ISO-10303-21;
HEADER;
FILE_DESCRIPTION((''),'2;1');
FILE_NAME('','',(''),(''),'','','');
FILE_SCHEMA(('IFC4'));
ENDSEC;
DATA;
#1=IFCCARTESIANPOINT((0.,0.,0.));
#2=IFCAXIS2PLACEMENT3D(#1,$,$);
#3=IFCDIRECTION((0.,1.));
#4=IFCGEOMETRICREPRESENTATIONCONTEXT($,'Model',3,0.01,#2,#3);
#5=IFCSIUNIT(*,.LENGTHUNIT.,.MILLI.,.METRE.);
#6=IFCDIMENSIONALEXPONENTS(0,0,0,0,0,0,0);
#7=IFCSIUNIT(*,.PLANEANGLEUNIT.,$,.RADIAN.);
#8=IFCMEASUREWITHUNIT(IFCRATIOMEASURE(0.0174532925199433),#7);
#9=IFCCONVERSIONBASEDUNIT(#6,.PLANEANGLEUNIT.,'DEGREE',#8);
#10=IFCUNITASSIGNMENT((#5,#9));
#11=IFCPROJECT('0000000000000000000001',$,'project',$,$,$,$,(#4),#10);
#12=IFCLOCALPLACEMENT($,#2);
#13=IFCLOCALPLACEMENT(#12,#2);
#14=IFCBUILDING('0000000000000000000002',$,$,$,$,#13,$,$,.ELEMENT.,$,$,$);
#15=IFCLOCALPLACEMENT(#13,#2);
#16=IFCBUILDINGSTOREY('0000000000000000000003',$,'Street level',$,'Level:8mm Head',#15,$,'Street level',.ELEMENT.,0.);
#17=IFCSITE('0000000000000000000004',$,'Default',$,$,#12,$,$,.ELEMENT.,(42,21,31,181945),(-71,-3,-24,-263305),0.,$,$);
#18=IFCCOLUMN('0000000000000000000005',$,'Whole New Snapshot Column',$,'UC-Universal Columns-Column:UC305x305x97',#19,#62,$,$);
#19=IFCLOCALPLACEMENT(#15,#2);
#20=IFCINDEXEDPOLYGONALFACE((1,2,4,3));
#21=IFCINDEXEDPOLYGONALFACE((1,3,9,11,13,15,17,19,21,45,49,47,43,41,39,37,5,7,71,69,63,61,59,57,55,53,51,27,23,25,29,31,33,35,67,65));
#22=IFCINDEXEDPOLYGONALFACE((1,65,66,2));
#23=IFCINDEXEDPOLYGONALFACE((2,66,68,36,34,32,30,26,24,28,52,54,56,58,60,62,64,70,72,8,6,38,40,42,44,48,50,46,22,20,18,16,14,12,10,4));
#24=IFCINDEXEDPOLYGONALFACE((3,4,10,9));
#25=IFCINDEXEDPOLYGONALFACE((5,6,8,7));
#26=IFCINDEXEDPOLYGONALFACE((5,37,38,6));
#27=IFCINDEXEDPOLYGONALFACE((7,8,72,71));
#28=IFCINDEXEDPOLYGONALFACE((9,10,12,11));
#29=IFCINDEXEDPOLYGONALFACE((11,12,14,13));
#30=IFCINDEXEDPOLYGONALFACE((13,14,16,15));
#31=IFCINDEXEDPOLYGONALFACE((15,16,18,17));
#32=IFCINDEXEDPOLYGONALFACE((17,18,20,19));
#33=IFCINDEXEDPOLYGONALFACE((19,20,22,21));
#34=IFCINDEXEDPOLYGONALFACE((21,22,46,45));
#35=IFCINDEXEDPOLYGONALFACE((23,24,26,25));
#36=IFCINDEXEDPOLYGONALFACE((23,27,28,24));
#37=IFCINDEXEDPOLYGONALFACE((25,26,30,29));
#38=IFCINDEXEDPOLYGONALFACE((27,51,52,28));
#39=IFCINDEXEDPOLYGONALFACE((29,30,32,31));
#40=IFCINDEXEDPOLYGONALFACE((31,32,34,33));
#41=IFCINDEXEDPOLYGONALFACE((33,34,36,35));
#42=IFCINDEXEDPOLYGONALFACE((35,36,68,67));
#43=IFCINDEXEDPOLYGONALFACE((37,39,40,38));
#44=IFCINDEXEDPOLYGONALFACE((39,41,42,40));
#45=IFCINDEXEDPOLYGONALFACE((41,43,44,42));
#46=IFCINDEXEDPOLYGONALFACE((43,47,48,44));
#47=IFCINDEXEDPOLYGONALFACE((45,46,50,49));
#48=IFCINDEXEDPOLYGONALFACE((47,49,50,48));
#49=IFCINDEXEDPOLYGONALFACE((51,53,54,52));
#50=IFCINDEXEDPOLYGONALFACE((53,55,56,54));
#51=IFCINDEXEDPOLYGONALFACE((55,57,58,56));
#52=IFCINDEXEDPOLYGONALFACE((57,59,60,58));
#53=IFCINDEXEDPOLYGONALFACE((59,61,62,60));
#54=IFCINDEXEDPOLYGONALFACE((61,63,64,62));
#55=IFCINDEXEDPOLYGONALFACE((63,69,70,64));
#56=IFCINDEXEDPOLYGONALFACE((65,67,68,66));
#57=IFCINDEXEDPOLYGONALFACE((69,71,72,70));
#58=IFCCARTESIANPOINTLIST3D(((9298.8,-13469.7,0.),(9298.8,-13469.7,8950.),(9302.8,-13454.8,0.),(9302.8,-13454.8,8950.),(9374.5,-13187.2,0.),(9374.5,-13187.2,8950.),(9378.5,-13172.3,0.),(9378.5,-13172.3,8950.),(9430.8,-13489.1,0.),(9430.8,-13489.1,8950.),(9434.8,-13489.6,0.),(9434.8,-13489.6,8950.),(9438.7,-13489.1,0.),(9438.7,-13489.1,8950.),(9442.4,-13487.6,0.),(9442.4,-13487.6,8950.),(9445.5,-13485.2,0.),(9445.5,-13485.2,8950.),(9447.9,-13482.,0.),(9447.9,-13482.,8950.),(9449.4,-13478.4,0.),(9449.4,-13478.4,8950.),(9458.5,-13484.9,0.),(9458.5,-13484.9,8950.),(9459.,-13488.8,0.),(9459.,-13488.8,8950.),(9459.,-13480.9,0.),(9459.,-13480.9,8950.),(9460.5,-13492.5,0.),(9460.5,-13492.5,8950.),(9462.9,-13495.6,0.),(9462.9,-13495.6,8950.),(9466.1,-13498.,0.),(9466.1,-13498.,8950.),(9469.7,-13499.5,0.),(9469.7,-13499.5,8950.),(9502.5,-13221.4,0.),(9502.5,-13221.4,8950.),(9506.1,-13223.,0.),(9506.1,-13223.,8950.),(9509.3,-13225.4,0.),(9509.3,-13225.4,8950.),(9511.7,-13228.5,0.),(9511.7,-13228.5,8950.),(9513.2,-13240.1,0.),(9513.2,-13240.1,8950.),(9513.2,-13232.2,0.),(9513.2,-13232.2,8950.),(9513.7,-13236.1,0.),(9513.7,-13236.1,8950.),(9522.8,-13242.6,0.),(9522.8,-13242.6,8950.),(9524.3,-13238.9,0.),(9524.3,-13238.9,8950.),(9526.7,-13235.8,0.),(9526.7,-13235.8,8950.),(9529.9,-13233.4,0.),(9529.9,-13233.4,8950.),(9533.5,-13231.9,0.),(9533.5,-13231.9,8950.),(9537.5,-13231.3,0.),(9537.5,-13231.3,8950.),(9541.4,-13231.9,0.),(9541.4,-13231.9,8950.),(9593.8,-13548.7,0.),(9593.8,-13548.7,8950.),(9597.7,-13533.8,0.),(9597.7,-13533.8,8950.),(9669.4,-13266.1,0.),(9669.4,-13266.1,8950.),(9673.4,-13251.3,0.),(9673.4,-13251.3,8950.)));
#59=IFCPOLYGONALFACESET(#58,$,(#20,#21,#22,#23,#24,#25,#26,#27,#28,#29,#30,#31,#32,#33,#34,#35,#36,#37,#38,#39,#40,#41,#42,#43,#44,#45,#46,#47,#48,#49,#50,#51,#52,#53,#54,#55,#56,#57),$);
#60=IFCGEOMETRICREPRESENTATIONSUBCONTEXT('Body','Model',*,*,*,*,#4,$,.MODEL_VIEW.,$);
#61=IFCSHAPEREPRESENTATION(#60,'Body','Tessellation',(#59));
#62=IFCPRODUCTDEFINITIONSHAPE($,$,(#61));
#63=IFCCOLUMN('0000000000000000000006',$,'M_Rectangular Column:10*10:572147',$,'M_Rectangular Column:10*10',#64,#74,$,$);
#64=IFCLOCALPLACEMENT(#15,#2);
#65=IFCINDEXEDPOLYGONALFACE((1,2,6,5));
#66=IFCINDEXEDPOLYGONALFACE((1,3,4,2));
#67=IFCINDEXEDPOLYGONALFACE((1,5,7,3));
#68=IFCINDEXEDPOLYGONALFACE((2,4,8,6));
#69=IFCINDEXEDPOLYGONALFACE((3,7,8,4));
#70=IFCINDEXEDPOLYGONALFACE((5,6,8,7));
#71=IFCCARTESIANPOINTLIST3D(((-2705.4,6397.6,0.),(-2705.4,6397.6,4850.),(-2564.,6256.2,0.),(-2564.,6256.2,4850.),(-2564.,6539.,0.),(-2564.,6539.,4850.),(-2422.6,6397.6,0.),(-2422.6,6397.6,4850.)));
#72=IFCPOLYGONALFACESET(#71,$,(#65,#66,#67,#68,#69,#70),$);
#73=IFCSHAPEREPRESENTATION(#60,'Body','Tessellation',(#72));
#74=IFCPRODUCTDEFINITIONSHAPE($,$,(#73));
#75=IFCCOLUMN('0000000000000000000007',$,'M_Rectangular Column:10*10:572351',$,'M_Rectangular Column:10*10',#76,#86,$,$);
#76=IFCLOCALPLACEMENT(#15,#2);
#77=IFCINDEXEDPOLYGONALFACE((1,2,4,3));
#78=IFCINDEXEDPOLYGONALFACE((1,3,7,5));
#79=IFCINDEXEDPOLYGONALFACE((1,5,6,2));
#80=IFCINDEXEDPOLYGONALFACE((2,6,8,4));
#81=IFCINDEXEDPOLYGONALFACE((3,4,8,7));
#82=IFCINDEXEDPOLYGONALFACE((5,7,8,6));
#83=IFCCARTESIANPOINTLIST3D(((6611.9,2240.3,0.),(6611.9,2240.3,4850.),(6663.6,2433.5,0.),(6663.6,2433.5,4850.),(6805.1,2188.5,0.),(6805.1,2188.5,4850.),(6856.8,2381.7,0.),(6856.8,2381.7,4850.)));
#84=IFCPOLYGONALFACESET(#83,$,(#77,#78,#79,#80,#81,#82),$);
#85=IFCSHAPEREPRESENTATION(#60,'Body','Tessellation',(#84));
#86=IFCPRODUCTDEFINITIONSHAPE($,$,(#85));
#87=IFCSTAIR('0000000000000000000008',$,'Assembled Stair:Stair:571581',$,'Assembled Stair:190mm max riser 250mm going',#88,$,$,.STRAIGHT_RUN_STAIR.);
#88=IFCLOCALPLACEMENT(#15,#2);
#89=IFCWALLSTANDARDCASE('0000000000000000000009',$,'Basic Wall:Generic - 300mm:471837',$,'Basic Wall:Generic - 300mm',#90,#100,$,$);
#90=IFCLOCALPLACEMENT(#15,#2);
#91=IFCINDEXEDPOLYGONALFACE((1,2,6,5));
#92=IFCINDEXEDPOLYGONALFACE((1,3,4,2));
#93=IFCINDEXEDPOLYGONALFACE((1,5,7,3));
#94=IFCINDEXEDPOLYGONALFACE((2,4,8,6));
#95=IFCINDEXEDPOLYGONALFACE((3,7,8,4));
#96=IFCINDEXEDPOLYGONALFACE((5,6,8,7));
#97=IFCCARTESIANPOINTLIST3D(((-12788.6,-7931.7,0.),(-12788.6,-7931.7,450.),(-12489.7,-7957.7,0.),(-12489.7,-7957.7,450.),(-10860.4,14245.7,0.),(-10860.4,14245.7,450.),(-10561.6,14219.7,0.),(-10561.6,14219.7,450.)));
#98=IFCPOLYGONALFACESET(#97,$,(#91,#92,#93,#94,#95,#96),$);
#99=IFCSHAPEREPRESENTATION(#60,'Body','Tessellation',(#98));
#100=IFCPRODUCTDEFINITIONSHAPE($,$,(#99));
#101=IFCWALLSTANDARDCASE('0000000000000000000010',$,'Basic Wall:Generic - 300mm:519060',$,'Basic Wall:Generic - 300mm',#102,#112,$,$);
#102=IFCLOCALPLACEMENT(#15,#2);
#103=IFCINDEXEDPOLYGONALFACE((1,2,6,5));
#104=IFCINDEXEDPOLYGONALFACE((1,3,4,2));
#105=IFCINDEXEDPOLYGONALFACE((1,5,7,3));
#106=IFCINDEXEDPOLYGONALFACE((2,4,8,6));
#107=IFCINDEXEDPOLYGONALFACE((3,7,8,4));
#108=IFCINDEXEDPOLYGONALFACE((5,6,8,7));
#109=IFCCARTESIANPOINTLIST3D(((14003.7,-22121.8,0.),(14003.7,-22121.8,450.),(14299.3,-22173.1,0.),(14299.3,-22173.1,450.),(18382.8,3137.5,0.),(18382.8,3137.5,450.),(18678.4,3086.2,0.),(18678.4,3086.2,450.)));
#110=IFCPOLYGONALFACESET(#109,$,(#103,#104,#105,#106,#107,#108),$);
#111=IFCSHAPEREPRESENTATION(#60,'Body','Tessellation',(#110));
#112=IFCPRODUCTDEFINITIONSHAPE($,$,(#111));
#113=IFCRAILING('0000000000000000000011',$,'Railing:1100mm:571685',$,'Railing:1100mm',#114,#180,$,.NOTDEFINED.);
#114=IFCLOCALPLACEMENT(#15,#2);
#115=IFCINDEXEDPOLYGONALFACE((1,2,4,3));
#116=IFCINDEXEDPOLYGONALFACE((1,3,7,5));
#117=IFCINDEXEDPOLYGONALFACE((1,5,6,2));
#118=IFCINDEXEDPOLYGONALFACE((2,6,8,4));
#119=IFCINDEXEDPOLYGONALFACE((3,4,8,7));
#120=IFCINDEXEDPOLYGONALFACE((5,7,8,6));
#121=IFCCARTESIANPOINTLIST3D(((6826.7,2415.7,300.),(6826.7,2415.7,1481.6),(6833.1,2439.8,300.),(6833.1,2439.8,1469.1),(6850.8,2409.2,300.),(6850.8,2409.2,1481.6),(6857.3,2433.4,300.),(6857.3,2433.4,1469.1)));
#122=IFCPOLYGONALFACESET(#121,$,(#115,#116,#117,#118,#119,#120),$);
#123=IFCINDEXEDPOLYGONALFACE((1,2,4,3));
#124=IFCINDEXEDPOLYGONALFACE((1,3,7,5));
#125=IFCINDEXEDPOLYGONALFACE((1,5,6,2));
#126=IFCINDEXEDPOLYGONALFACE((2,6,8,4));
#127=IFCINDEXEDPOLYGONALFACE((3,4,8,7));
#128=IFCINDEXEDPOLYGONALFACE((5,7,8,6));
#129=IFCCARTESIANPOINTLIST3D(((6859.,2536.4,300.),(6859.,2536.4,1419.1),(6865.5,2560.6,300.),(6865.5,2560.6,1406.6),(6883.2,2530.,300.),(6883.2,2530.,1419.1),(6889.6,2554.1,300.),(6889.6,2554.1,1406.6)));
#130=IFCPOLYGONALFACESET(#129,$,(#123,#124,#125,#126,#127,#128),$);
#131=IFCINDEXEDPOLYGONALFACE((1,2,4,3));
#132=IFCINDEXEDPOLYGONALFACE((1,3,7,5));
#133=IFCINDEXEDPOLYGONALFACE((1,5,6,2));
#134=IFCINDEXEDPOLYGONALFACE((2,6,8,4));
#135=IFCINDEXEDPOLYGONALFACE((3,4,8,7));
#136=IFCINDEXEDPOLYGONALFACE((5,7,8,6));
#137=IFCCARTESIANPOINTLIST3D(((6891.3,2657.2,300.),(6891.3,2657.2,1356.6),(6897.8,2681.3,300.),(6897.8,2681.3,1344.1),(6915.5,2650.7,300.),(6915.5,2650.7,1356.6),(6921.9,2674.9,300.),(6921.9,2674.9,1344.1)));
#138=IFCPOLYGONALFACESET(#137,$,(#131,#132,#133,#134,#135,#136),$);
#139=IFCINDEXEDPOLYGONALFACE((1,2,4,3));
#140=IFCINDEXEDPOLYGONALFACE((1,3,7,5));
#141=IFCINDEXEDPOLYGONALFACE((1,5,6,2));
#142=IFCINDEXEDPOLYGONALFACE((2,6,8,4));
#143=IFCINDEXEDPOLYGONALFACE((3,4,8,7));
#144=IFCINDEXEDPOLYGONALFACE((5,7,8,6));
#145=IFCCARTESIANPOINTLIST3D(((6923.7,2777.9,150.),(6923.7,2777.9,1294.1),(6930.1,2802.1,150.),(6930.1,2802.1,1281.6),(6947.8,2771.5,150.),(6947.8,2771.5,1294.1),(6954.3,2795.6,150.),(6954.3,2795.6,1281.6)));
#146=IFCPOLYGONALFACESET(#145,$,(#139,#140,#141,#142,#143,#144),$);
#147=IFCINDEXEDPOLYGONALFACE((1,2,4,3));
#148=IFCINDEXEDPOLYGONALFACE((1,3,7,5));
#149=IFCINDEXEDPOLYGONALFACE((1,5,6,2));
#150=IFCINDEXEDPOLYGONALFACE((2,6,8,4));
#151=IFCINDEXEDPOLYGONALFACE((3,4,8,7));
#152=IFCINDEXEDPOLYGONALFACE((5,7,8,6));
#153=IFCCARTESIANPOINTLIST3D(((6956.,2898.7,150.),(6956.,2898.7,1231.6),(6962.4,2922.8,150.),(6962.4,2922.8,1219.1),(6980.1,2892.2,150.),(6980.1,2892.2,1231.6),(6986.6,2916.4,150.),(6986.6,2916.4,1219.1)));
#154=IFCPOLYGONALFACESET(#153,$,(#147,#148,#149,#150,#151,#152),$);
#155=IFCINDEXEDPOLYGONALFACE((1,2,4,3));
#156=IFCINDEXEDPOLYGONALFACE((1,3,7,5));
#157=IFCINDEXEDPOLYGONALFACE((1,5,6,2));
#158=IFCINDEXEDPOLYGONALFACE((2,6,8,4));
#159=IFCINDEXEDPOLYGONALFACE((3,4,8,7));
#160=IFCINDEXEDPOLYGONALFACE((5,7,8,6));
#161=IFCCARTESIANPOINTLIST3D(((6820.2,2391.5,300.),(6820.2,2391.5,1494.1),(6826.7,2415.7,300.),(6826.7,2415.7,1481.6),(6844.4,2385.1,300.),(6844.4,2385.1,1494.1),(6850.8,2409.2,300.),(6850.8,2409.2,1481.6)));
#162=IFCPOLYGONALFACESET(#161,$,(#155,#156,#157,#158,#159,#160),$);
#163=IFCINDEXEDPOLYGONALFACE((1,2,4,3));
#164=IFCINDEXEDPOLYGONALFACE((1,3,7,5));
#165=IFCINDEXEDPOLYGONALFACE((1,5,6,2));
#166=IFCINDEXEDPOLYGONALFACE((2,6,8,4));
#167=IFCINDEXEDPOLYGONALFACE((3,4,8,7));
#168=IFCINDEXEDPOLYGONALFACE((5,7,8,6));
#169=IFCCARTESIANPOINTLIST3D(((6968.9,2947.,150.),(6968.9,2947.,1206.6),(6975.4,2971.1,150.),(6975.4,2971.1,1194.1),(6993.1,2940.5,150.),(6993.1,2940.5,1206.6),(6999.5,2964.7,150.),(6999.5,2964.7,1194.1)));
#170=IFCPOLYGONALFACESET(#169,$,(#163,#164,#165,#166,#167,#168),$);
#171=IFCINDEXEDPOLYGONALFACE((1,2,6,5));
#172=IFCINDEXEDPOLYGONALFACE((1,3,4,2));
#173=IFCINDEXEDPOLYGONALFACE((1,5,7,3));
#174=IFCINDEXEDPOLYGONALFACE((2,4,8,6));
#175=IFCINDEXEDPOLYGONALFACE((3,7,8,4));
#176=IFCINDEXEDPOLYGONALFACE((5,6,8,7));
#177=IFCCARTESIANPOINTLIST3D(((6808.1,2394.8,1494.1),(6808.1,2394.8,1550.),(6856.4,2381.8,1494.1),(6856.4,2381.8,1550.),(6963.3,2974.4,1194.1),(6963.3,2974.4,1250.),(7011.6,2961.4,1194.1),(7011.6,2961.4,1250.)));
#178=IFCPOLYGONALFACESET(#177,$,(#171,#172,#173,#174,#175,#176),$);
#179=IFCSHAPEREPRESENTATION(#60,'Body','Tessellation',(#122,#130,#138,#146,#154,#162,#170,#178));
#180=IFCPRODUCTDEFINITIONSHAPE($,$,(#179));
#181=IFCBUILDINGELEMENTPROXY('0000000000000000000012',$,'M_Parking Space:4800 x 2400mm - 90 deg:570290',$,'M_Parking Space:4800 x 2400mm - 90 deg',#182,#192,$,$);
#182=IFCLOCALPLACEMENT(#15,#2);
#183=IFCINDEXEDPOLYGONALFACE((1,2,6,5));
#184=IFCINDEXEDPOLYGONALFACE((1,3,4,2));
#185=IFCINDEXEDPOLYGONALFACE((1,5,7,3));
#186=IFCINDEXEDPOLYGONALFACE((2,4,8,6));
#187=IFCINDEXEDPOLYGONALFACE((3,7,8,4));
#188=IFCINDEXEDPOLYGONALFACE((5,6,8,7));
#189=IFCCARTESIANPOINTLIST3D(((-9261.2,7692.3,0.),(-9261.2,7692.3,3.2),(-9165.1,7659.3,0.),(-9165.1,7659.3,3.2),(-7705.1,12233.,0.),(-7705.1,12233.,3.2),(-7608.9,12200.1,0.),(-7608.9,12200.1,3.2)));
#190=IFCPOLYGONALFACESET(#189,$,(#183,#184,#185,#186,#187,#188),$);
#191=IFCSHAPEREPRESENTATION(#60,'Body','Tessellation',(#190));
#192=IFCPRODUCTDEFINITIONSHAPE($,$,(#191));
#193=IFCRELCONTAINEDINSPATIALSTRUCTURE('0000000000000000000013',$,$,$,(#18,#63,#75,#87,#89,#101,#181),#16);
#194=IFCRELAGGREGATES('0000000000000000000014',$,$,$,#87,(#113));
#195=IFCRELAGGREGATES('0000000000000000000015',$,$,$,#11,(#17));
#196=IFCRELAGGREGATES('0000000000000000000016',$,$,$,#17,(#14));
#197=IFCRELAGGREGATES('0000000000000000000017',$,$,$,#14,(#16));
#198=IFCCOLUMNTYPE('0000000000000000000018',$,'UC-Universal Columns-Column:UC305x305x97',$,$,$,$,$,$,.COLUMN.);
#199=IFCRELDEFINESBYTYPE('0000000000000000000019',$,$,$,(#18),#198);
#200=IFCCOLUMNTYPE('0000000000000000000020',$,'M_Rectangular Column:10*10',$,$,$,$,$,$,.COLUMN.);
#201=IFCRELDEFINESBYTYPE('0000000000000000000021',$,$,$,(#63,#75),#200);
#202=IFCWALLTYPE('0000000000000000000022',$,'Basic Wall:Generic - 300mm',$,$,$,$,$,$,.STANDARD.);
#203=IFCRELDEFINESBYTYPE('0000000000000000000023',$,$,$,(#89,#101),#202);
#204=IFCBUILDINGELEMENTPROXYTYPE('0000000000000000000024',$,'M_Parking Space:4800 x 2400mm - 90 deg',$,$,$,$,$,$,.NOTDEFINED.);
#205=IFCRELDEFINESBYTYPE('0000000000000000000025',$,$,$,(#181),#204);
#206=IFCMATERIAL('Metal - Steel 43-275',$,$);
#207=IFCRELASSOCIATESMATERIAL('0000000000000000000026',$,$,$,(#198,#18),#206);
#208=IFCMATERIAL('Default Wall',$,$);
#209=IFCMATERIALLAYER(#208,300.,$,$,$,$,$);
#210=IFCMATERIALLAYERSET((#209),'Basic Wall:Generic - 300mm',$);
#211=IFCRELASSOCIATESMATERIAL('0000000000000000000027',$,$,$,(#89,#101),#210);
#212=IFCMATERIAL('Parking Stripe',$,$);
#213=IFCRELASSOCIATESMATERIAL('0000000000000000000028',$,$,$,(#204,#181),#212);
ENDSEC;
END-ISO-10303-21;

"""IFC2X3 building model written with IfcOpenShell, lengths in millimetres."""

from ifc_helpers import new_model, entity, si_unit, converted_unit, direction, frame, frame_2d, origin, origin_2d_with_axis, place, context, subcontext, project, spatial, polyline, rectangle, i_section, outline, extrude, source, transform, mapped, material, layer, layer_set, layer_usage, type_object, type_shapes, element, aggregate, save


model = new_model("IFC2X3")

# Units and contexts
model_context = context("Model", 3, precision=0.01, world=origin(), true_north=direction((0.0, 1.0)))
body_context = subcontext(model_context, "Body", "Model", "MODEL_VIEW")
ifc_project = project(units=[si_unit("LENGTHUNIT", "METRE", prefix="MILLI"), converted_unit("PLANEANGLEUNIT", "DEGREE", entity("IfcRatioMeasure", 0.0174532925199433), si_unit("PLANEANGLEUNIT", "RADIAN"), dimensions=[0, 0, 0, 0, 0, 0, 0])], contexts=[model_context])

# Site, building, storey
site_placement = place(None, origin())
site = spatial("IfcSite", under=ifc_project, at=site_placement, Name="Default", CompositionType="ELEMENT", RefLatitude=(42, 21, 31, 181945), RefLongitude=(-71, -3, -24, -263305), RefElevation=0.0)
building_placement = place(site_placement, origin())
building = spatial("IfcBuilding", under=site, at=building_placement, CompositionType="ELEMENT")
storey_placement = place(building_placement, origin())
storey = spatial("IfcBuildingStorey", under=building, at=storey_placement, Name="Street level", ObjectType="Level:8mm Head", LongName="Street level", CompositionType="ELEMENT", Elevation=0.0)

# Columns
ifc_material_1 = material(Name="Metal - Steel 43-275")
column_type_1 = type_object("IfcColumnType", Name="UC-Universal Columns-Column:UC305x305x97", PredefinedType="COLUMN", material=ifc_material_1)
shared_shape_1 = source(origin(), body_context, "Body", "SweptSolid", [
    extrude(i_section(OverallWidth=305.3, OverallDepth=307.9, WebThickness=9.9, FlangeThickness=15.4, FilletRadius=15.2, at=frame_2d((0.0, 0.0), x_axis=(0.0, 1.0))), frame((0.0, 0.0, 0.0), z_axis=(0.0, 0.0, 1.0), x_axis=(0.0, -1.0, 0.0)), (0.0, 0.0, 1.0), 8950.0),
])
type_shapes(column_type_1, [shared_shape_1])
column_placement = place(storey_placement, frame((9486.1, -13360.5, 0.0), z_axis=(0.0, 0.0, 1.0), x_axis=(0.965983, -0.258607, 0.0)))
element("IfcColumn", 1, at=column_placement, inside=storey, type_object=column_type_1, material=ifc_material_1, Name="Whole New Snapshot Column", ObjectType="UC-Universal Columns-Column:UC305x305x97", context=body_context, shape_type="MappedRepresentation", body=[
    mapped(shared_shape_1, transform((0.0, 0.0, 0.0), scale=1.0)),
])
column_type_2 = type_object("IfcColumnType", Name="M_Rectangular Column:10*10", PredefinedType="COLUMN")
shared_shape_2 = source(origin(), body_context, "Body", "SweptSolid", [
    extrude(rectangle(XDim=200.0, YDim=200.0, at=origin_2d_with_axis()), frame((0.0, 0.0, 0.0), z_axis=(0.0, 0.0, 1.0), x_axis=(0.0, -1.0, 0.0)), (0.0, 0.0, 1.0), 4850.0),
])
type_shapes(column_type_2, [shared_shape_2])
for number, where, z_axis, x_axis, name in (
    (2, (-2564.0, 6397.6, 0.0), (0.0, 0.0, 1.0), (0.707107, 0.707107, 0.0), "M_Rectangular Column:10*10:572147"),
    (3, (6734.4, 2311.0, 0.0), (0.0, 0.0, 1.0), (0.258607, 0.965983, 0.0), "M_Rectangular Column:10*10:572351"),
):
    element("IfcColumn", number, at=place(storey_placement, frame(where, z_axis=z_axis, x_axis=x_axis)), inside=storey, type_object=column_type_2, Name=name, ObjectType="M_Rectangular Column:10*10", context=body_context, shape_type="MappedRepresentation", body=[
        mapped(shared_shape_2, transform((0.0, 0.0, 0.0), scale=1.0)),
    ])

# Stair
stair_placement = place(storey_placement, origin())
stair = element("IfcStair", 4, at=stair_placement, inside=storey, Name="Assembled Stair:Stair:571581", ObjectType="Assembled Stair:190mm max riser 250mm going", ShapeType="STRAIGHT_RUN_STAIR")

# Walls
ifc_material_2 = material(Name="Default Wall")
ifc_layer_1 = layer(ifc_material_2, 300.0)
ifc_layer_set_1 = layer_set([ifc_layer_1], Name="Basic Wall:Generic - 300mm")
ifc_layer_usage_1 = layer_usage(ifc_layer_set_1, "AXIS2", "NEGATIVE", 150.0)
wall_type = type_object("IfcWallType", Name="Basic Wall:Generic - 300mm", PredefinedType="STANDARD")
wall_1_placement = place(storey_placement, frame((-10711.0, 14232.7, 0.0), z_axis=(0.0, 0.0, 1.0), x_axis=(-0.086615, -0.996242, 0.0)))
element("IfcWallStandardCase", 5, at=wall_1_placement, inside=storey, type_object=wall_type, material=ifc_layer_usage_1, Name="Basic Wall:Generic - 300mm:471837", ObjectType="Basic Wall:Generic - 300mm", context=body_context, shape_type="SweptSolid", body=[
    extrude(rectangle(XDim=22261.1, YDim=300.0, at=frame_2d((11130.5, 0.0), x_axis=(-1.0, 0.0))), origin(), (0.0, 0.0, 1.0), 450.0),
])
ifc_layer_usage_2 = layer_usage(ifc_layer_set_1, "AXIS2", "NEGATIVE", 150.0)
wall_2_placement = place(storey_placement, frame((14151.5, -22147.4, 0.0), z_axis=(0.0, 0.0, 1.0), x_axis=(0.17082, 0.985302, 0.0)))
element("IfcWallStandardCase", 6, at=wall_2_placement, inside=storey, type_object=wall_type, material=ifc_layer_usage_2, Name="Basic Wall:Generic - 300mm:519060", ObjectType="Basic Wall:Generic - 300mm", context=body_context, shape_type="SweptSolid", body=[
    extrude(rectangle(XDim=25636.1, YDim=300.0, at=frame_2d((12818.0, 0.0), x_axis=(-1.0, 0.0))), origin(), (0.0, 0.0, 1.0), 450.0),
])

# Railing
railing_placement = place(stair_placement, origin())
railing = element("IfcRailing", 7, at=railing_placement, Name="Railing:1100mm:571685", ObjectType="Railing:1100mm", PredefinedType="NOTDEFINED", context=body_context, shape_type="SweptSolid", body=[
    extrude(outline(polyline([(-587.7, -12.5), (581.4, -12.5), (593.9, 12.5), (-587.7, 12.5), (-587.7, -12.5)])), frame((6829.9, 2427.8, 887.7), z_axis=(0.965983, -0.258606, 0.0), x_axis=(0.0, 0.0, 1.0)), (0.0, 0.0, 1.0), 25.0),
    extrude(outline(polyline([(-556.4, -12.5), (550.2, -12.5), (562.7, 12.5), (-556.4, 12.5), (-556.4, -12.5)])), frame((6862.2, 2548.5, 856.4), z_axis=(0.965983, -0.258606, 0.0), x_axis=(0.0, 0.0, 1.0)), (0.0, 0.0, 1.0), 25.0),
    extrude(outline(polyline([(-525.2, -12.5), (518.9, -12.5), (531.4, 12.5), (-525.2, 12.5), (-525.2, -12.5)])), frame((6894.6, 2669.3, 825.2), z_axis=(0.965983, -0.258606, 0.0), x_axis=(0.0, 0.0, 1.0)), (0.0, 0.0, 1.0), 25.0),
    extrude(outline(polyline([(-568.9, -12.5), (562.7, -12.5), (575.2, 12.5), (-568.9, 12.5), (-568.9, -12.5)])), frame((6926.9, 2790.0, 718.9), z_axis=(0.965983, -0.258606, 0.0), x_axis=(0.0, 0.0, 1.0)), (0.0, 0.0, 1.0), 25.0),
    extrude(outline(polyline([(-537.7, -12.5), (531.4, -12.5), (543.9, 12.5), (-537.7, 12.5), (-537.7, -12.5)])), frame((6959.2, 2910.8, 687.7), z_axis=(0.965983, -0.258606, 0.0), x_axis=(0.0, 0.0, 1.0)), (0.0, 0.0, 1.0), 25.0),
    extrude(outline(polyline([(-593.9, -12.5), (587.7, -12.5), (600.2, 12.5), (-593.9, 12.5), (-593.9, -12.5)])), frame((6823.4, 2403.6, 893.9), z_axis=(0.965983, -0.258606, 0.0), x_axis=(0.0, 0.0, 1.0)), (0.0, 0.0, 1.0), 25.0),
    extrude(outline(polyline([(-525.2, -12.5), (518.9, -12.5), (531.4, 12.5), (-525.2, 12.5), (-525.2, -12.5)])), frame((6972.1, 2959.1, 675.2), z_axis=(0.965983, -0.258606, 0.0), x_axis=(0.0, 0.0, 1.0)), (0.0, 0.0, 1.0), 25.0),
    extrude(outline(polyline([(-322.9, -25.0), (347.9, -25.0), (322.9, 25.0), (-347.9, 25.0), (-322.9, -25.0)])), frame((6885.7, 2684.6, 1372.0), z_axis=(0.965983, -0.258606, 0.0), x_axis=(-0.231304, -0.864001, 0.447214)), (0.0, 0.0, 1.0), 50.0),
])
aggregate(stair, [railing])

# Building element proxy
ifc_material_3 = material(Name="Parking Stripe")
building_element_proxy_type = type_object("IfcBuildingElementProxyType", Name="M_Parking Space:4800 x 2400mm - 90 deg", PredefinedType="NOTDEFINED", material=ifc_material_3)
shared_shape_3 = source(origin(), body_context, "Body", "SweptSolid", [
    extrude(rectangle(XDim=101.6, YDim=4800.0, at=origin_2d_with_axis()), frame((0.0, 2400.0, 0.0)), (0.0, 0.0, 1.0), 3.2),
])
type_shapes(building_element_proxy_type, [shared_shape_3])
for number, where, z_axis, x_axis, name in (
    (8, (-9213.1, 7675.8, 0.0), (0.0, 0.0, 1.0), (0.945989, -0.324198, 0.0), "M_Parking Space:4800 x 2400mm - 90 deg:570290"),
):
    element("IfcBuildingElementProxy", number, at=place(storey_placement, frame(where, z_axis=z_axis, x_axis=x_axis)), inside=storey, type_object=building_element_proxy_type, material=ifc_material_3, Name=name, ObjectType="M_Parking Space:4800 x 2400mm - 90 deg", context=body_context, shape_type="MappedRepresentation", body=[
        mapped(shared_shape_3, transform((0.0, 0.0, 0.0), scale=1.0)),
    ])

save(model, "model.ifc")
